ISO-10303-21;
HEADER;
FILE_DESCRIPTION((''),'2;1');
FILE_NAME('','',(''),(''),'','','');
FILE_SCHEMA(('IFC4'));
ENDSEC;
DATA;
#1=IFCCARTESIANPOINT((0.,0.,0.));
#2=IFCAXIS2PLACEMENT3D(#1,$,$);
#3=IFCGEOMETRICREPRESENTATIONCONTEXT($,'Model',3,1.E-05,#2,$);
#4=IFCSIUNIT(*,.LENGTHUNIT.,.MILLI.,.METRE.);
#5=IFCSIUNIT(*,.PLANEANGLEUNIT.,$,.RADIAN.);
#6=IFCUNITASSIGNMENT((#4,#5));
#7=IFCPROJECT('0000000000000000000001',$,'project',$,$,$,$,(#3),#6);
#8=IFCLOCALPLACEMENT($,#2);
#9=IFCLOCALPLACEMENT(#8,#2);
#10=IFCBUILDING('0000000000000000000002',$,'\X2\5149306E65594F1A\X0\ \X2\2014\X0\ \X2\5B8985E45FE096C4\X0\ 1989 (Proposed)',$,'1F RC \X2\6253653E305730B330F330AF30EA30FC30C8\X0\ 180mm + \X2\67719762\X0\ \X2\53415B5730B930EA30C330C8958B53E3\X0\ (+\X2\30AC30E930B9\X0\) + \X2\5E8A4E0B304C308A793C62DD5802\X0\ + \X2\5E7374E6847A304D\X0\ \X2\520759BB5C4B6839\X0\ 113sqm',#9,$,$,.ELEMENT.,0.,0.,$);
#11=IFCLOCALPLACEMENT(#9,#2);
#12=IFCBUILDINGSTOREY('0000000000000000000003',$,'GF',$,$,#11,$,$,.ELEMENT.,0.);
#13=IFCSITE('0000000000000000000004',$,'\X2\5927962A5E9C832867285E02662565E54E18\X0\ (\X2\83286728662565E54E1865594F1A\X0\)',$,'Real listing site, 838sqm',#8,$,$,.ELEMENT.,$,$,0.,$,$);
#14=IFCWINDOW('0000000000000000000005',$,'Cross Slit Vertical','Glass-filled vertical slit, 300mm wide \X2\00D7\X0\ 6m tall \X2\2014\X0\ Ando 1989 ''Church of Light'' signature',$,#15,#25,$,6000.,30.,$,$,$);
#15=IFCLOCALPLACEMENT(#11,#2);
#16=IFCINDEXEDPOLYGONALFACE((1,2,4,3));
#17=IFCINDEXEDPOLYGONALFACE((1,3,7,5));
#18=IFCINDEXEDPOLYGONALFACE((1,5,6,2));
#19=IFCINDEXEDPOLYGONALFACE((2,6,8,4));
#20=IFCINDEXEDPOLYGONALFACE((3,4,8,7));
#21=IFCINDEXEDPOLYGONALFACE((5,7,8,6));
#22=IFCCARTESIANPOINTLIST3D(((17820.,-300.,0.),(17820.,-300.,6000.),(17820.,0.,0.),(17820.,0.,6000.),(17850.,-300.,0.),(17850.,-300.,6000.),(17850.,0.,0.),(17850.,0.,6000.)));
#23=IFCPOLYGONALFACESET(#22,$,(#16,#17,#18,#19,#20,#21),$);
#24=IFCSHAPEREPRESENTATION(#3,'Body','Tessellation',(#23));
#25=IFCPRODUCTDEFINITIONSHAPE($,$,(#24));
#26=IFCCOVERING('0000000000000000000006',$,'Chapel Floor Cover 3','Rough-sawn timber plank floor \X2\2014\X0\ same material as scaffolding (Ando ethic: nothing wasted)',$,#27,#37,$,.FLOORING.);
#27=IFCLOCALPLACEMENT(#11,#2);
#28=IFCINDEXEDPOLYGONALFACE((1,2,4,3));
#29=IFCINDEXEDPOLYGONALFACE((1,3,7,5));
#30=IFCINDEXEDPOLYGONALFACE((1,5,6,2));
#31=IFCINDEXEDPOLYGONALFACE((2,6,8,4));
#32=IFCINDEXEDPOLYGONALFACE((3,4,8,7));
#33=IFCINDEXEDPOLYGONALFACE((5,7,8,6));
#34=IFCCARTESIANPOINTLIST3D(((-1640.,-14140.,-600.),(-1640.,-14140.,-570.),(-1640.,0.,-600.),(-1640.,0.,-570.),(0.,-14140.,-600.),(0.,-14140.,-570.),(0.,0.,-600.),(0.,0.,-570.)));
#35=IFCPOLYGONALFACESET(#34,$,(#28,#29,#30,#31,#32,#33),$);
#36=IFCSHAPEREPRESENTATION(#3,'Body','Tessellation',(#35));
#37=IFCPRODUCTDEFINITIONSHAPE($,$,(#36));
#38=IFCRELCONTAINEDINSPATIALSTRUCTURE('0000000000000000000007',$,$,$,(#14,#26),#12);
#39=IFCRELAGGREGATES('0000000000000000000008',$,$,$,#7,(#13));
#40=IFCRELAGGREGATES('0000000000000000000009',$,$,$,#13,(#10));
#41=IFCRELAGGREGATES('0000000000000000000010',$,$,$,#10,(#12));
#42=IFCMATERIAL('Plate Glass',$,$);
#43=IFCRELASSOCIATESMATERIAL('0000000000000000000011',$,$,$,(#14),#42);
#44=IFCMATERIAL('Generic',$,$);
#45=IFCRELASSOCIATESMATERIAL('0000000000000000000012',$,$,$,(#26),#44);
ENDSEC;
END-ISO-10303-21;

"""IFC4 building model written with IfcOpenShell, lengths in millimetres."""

from ifc_helpers import new_model, si_unit, frame, frame_2d, origin, place, context, project, spatial, rectangle, extrude, material, element, save


model = new_model("IFC4")

# Units and contexts
model_context = context("Model", 3, precision=1e-05, world=origin())
ifc_project = project(units=[si_unit("LENGTHUNIT", "METRE", prefix="MILLI"), si_unit("PLANEANGLEUNIT", "RADIAN")], contexts=[model_context])

# Site, building, storey
site_placement = place(None, origin())
site = spatial("IfcSite", under=ifc_project, at=site_placement, Name="大阪府茨木市春日丘 (茨木春日丘教会)", ObjectType="Real listing site, 838sqm", CompositionType="ELEMENT", RefElevation=0.0)
building_placement = place(site_placement, origin())
building = spatial("IfcBuilding", under=site, at=building_placement, Name="光の教会 — 安藤忠雄 1989 (Proposed)", ObjectType="1F RC 打放しコンクリート 180mm + 東面 十字スリット開口 (+ガラス) + 床下がり礼拝堂 + 平瓦葺き 切妻屋根 113sqm", CompositionType="ELEMENT", ElevationOfRefHeight=0.0, ElevationOfTerrain=0.0)
storey_placement = place(building_placement, origin())
storey = spatial("IfcBuildingStorey", under=building, at=storey_placement, Name="GF", CompositionType="ELEMENT", Elevation=0.0)

# Shared definitions
ifc_material_1 = material(Name="Generic")

# Window
ifc_material_2 = material(Name="Plate Glass")
window_placement = place(storey_placement, frame((8910.0, -150.0, 0.0)))
element("IfcWindow", 1, at=window_placement, inside=storey, material=ifc_material_2, Name="Cross Slit Vertical", Description="Glass-filled vertical slit, 300mm wide × 6m tall — Ando 1989 'Church of Light' signature", OverallHeight=6000.0, OverallWidth=30.0, context=model_context, shape_type="SweptSolid", body=[
    extrude(rectangle(XDim=30.0, YDim=300.0, at=frame_2d((15.0, 150.0))), frame((8910.0, -150.0, 0.0)), (0.0, 0.0, 1.0), 6000.0),
])

# Covering
covering_1_placement = place(storey_placement, frame((-820.0, -7070.0, -300.0)))
element("IfcCovering", 2, at=covering_1_placement, inside=storey, material=ifc_material_1, Name="Chapel Floor Cover 3", Description="Rough-sawn timber plank floor — same material as scaffolding (Ando ethic: nothing wasted)", PredefinedType="FLOORING", context=model_context, shape_type="SweptSolid", body=[
    extrude(rectangle(XDim=1640.0, YDim=14140.0, at=frame_2d((820.0, 7070.0))), frame((-820.0, -7070.0, -300.0)), (0.0, 0.0, 1.0), 30.0),
])

save(model, "model.ifc")
